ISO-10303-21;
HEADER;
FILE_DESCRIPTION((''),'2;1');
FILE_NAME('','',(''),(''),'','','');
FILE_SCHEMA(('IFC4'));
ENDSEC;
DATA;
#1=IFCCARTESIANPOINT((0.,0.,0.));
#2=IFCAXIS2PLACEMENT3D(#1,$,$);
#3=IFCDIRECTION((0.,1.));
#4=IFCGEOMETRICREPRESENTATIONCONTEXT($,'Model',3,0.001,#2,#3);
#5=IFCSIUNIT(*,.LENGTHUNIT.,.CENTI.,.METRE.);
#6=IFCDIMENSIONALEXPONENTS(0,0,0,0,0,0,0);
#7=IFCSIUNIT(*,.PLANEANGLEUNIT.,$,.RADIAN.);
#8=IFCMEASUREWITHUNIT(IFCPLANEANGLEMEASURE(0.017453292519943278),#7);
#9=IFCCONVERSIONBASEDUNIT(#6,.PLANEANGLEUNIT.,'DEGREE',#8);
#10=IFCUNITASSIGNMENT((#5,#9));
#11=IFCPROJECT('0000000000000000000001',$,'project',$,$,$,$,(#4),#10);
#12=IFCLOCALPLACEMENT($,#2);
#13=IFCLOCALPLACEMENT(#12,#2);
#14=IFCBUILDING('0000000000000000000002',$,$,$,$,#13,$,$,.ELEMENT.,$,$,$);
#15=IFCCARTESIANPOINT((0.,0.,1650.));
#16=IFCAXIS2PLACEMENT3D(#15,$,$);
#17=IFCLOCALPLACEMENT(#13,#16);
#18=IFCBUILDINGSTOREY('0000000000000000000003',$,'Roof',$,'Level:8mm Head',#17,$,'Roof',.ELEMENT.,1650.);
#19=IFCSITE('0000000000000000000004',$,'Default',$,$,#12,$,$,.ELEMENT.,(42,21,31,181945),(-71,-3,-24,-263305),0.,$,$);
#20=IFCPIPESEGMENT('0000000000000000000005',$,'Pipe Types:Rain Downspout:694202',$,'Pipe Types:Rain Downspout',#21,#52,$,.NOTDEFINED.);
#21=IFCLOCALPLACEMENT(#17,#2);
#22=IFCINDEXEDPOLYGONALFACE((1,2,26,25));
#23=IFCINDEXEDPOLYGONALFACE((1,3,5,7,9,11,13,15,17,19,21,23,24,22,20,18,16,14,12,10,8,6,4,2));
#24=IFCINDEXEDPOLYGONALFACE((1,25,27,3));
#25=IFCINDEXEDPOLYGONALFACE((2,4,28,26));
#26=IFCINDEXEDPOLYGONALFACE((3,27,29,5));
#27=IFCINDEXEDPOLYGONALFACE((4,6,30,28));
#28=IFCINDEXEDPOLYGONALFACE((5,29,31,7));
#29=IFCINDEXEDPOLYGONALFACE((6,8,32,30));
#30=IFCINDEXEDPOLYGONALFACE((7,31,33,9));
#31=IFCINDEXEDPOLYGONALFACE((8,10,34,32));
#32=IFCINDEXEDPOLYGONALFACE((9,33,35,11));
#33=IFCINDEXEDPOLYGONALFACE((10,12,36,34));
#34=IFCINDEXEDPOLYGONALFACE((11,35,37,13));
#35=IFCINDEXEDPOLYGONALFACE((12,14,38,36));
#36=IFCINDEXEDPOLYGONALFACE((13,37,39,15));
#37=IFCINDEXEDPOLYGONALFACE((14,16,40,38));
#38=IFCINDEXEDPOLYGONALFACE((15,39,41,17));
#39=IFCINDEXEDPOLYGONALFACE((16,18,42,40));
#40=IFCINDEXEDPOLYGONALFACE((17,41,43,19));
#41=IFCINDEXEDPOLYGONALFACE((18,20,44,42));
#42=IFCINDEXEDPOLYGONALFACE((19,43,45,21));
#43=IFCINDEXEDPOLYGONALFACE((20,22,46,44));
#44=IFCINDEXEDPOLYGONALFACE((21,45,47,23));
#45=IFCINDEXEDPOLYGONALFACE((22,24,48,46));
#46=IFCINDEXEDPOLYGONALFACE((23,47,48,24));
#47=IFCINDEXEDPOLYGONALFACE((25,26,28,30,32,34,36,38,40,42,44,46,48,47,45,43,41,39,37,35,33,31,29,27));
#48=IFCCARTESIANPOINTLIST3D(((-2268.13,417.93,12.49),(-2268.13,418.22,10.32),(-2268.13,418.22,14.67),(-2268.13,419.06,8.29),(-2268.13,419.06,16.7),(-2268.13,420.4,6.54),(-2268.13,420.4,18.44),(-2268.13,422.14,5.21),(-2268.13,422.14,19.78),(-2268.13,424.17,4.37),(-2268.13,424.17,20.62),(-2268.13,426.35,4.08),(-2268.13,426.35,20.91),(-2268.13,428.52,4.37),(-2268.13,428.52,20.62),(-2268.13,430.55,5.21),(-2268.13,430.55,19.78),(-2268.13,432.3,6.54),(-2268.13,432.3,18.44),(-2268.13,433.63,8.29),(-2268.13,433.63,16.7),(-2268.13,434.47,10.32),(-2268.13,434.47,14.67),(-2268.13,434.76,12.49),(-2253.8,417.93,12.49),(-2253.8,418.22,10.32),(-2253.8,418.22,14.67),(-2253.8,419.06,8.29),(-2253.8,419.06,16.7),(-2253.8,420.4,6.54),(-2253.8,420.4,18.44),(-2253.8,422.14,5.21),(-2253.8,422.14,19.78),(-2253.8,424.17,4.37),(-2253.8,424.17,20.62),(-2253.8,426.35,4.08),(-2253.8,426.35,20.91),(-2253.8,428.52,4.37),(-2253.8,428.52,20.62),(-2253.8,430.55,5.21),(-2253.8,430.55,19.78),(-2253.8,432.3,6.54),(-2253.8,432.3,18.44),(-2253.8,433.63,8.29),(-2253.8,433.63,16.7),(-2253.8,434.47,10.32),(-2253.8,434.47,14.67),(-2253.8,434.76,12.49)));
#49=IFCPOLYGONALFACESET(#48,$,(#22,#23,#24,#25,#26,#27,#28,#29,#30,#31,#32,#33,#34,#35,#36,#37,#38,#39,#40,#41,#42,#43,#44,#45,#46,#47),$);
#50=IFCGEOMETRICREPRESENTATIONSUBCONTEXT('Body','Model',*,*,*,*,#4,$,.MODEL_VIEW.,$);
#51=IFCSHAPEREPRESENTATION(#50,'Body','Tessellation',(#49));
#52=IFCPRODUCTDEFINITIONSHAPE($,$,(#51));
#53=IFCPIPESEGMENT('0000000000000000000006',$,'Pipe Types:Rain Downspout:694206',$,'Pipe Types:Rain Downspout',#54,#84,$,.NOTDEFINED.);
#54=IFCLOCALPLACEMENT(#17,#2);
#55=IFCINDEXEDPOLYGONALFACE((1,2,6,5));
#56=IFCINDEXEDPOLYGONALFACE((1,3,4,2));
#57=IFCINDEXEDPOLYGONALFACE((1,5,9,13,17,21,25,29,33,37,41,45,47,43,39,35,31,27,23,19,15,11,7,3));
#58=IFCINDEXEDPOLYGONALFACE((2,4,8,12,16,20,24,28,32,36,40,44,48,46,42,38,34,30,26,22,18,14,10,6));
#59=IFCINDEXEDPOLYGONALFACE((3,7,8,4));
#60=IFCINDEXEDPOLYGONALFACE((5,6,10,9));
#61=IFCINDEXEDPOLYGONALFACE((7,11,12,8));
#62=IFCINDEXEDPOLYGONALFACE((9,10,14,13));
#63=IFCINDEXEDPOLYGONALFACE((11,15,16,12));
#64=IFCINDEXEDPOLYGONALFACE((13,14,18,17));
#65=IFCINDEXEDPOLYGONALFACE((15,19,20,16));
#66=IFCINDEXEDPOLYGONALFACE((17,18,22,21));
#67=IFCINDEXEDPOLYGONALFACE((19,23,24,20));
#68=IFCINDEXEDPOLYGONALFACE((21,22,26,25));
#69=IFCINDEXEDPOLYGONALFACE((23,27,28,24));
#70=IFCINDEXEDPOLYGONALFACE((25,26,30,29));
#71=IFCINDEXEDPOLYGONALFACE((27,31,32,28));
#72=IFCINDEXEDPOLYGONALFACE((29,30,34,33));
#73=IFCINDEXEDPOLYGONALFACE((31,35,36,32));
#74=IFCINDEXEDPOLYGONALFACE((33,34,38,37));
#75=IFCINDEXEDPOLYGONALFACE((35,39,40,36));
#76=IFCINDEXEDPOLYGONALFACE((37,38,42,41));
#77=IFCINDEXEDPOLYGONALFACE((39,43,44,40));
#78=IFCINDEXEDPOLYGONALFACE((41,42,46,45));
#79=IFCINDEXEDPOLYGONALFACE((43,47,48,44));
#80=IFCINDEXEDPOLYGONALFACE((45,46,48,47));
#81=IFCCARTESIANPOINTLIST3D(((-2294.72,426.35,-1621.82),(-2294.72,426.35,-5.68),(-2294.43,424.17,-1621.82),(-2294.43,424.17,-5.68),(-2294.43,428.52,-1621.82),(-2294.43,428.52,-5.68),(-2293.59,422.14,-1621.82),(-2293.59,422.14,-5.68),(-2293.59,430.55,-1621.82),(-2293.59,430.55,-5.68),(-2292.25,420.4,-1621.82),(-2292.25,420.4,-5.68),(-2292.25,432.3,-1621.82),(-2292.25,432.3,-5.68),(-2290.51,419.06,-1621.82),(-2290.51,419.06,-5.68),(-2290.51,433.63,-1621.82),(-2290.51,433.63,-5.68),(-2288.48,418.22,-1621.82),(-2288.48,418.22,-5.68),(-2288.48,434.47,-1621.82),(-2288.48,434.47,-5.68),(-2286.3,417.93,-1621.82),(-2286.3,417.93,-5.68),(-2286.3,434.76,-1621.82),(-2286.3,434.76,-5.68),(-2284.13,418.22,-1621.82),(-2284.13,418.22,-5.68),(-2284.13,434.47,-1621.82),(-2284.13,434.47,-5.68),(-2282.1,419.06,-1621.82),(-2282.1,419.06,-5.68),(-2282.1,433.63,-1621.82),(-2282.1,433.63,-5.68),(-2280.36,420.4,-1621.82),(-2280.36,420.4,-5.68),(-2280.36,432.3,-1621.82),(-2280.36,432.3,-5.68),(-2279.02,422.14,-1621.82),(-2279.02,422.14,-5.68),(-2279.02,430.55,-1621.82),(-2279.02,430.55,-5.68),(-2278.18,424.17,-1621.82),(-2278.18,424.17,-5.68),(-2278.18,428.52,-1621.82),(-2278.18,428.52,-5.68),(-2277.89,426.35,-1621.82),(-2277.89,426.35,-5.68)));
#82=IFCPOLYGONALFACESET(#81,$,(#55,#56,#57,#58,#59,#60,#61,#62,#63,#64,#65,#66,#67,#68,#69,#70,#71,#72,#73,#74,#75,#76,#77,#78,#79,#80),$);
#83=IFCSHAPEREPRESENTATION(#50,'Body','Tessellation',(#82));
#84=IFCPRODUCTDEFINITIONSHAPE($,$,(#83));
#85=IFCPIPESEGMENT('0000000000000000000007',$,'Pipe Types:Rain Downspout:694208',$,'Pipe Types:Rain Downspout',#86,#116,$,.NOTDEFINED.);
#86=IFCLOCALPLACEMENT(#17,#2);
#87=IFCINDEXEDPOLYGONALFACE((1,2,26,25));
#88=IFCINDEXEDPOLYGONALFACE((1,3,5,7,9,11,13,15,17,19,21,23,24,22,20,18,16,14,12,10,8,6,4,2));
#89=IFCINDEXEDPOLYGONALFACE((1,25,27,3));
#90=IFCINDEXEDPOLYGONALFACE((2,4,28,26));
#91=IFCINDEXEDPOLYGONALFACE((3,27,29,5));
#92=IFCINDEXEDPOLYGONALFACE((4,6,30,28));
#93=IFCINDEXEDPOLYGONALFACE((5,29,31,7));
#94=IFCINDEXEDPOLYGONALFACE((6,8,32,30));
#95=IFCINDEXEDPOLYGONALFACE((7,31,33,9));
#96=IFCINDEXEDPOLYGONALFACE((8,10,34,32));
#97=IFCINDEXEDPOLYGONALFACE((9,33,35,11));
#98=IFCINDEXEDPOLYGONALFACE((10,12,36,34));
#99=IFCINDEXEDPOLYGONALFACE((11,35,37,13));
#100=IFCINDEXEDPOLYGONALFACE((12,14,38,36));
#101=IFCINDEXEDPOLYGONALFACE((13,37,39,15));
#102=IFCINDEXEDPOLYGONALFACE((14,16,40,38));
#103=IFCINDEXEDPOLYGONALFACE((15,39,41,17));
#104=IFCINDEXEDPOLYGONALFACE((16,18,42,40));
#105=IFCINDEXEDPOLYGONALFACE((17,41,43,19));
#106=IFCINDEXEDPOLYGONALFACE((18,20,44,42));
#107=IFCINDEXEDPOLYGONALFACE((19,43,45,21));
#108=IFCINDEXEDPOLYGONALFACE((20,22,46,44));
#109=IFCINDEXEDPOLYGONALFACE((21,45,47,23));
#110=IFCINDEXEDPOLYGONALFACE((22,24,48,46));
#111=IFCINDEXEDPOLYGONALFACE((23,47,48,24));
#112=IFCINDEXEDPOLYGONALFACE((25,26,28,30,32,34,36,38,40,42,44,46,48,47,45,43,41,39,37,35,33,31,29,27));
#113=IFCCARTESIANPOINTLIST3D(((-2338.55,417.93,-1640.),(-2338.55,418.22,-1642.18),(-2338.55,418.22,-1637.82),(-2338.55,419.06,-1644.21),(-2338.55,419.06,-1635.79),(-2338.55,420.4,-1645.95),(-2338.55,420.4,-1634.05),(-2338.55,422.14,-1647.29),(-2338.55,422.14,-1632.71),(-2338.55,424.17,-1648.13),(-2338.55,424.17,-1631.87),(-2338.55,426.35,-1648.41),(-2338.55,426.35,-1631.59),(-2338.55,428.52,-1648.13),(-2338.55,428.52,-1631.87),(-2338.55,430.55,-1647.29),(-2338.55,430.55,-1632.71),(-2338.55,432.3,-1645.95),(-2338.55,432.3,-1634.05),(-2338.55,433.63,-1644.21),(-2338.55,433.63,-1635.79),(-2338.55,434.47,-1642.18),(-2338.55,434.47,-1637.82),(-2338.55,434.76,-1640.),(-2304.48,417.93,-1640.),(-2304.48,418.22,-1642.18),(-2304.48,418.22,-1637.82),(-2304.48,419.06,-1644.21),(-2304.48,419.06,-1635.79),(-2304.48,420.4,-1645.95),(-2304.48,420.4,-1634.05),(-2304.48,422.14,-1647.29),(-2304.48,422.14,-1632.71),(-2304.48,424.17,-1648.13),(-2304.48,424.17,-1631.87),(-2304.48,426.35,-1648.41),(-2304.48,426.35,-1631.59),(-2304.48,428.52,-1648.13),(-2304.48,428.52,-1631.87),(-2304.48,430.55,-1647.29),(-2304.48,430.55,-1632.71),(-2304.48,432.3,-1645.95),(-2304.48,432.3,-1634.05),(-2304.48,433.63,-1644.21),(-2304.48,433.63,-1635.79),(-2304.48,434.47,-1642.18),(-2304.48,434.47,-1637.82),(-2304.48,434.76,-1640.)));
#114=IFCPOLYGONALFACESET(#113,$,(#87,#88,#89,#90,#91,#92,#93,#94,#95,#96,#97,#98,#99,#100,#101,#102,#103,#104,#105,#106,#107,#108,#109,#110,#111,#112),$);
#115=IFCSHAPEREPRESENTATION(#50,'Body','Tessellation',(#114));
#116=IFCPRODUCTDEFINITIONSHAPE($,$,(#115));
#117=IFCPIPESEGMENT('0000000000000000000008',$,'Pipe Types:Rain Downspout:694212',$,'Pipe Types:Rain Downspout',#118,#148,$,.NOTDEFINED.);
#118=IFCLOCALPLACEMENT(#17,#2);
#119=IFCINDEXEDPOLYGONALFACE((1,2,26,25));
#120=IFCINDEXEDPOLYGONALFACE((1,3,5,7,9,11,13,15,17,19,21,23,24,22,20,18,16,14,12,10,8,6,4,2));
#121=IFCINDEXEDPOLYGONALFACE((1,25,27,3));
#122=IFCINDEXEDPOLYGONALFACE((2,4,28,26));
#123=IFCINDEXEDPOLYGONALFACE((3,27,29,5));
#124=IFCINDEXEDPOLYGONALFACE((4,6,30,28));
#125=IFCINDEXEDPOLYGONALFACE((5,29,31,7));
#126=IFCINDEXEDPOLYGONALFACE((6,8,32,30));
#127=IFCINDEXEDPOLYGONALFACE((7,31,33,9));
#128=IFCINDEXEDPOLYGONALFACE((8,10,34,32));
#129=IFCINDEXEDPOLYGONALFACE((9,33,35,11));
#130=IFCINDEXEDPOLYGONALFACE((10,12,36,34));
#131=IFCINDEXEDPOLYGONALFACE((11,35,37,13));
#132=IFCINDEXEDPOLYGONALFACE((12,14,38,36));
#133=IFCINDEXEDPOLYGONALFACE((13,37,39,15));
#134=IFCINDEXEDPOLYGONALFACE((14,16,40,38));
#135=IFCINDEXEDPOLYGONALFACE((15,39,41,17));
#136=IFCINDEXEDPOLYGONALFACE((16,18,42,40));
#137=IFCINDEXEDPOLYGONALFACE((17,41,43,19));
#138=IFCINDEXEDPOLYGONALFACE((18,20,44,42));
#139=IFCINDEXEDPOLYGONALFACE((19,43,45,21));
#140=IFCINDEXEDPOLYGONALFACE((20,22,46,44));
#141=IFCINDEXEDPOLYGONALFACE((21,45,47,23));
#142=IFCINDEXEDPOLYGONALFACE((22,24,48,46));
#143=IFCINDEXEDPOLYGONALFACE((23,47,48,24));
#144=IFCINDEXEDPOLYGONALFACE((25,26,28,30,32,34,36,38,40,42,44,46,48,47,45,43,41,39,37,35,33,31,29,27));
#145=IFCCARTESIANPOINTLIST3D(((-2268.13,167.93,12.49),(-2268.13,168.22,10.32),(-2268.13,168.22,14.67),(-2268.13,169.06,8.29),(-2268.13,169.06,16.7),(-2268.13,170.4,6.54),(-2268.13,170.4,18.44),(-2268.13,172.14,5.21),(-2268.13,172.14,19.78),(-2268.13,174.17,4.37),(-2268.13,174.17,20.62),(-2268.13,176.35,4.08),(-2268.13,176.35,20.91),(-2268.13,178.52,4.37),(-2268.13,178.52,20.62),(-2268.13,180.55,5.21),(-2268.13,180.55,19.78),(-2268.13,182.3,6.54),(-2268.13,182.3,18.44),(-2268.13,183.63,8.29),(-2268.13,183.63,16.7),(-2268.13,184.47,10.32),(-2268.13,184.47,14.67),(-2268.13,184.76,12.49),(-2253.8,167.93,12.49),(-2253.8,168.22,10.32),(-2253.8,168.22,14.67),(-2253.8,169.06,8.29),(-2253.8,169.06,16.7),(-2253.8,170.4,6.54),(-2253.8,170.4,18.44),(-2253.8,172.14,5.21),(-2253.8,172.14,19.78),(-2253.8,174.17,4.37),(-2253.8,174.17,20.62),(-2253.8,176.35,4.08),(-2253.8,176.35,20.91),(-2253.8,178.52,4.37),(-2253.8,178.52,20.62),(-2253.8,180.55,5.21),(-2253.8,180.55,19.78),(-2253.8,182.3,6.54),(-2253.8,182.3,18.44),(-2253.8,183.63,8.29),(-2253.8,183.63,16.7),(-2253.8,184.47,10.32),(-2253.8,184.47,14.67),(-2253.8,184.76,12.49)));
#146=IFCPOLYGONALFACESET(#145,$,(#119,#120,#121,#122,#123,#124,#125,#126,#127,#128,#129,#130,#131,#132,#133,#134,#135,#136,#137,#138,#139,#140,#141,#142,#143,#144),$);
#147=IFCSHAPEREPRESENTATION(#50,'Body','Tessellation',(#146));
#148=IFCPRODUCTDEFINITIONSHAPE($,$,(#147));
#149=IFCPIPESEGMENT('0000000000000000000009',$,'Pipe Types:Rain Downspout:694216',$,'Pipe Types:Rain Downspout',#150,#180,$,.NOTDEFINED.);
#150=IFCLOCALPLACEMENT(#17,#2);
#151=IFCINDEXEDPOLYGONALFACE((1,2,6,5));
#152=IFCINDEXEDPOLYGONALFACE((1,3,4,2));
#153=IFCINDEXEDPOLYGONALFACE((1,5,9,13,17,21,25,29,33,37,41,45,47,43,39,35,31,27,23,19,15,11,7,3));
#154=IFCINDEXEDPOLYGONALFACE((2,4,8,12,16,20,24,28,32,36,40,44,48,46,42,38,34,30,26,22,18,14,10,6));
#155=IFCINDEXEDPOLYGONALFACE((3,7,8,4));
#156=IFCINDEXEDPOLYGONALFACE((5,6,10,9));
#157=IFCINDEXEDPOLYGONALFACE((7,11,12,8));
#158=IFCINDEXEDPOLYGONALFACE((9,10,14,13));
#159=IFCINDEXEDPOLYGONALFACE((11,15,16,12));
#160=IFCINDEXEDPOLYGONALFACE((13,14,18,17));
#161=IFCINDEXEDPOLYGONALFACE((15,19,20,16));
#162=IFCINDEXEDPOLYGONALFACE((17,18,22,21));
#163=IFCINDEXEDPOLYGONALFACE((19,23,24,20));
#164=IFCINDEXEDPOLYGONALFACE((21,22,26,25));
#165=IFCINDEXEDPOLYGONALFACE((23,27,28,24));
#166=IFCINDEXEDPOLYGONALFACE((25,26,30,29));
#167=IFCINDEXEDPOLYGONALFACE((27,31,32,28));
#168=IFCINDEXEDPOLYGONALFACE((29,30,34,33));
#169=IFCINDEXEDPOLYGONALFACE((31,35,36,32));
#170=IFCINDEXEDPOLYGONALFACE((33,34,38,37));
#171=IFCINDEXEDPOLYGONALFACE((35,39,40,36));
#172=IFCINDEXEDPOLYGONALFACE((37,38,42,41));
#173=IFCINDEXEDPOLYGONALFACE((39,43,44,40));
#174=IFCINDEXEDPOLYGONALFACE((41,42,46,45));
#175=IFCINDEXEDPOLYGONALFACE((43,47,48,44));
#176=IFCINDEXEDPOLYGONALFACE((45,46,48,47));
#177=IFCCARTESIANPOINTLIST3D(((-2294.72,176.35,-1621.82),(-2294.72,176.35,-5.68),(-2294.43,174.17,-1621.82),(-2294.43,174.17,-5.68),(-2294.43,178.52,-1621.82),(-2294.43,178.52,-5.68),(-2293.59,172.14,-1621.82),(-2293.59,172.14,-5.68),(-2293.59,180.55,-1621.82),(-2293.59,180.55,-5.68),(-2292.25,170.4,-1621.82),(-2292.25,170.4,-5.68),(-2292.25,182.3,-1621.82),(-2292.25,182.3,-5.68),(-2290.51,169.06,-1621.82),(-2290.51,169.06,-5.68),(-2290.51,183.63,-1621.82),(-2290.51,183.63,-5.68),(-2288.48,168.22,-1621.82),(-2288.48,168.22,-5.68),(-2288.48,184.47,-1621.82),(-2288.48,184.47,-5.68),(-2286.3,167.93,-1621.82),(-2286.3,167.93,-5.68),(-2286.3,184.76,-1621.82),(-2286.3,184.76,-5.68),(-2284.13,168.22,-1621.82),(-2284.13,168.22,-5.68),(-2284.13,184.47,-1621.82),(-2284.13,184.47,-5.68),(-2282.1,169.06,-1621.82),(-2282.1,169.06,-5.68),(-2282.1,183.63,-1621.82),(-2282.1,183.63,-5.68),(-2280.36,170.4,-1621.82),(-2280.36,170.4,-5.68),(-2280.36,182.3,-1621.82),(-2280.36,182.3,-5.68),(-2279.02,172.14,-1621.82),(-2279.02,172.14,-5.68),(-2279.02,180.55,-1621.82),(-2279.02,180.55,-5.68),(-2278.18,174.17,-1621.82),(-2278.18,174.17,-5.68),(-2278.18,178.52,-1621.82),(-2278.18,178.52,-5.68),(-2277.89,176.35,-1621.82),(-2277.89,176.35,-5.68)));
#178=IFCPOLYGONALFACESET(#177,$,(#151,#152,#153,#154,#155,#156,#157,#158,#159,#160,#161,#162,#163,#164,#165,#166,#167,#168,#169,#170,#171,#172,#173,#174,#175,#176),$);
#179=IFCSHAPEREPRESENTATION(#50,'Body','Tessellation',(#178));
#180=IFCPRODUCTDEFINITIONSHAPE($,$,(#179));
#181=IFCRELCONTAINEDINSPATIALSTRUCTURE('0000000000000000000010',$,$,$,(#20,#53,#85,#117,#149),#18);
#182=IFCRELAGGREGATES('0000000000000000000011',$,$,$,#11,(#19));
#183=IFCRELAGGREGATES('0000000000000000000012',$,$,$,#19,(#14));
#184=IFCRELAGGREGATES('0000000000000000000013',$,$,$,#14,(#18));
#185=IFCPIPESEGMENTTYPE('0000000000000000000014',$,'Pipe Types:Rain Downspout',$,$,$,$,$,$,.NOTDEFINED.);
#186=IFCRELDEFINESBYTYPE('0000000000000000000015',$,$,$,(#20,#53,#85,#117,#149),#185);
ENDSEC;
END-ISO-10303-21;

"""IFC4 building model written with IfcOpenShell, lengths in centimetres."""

from ifc_helpers import new_model, entity, si_unit, converted_unit, direction, frame, origin, place, context, subcontext, project, spatial, arc, indexed_curve, outline, extrude, type_object, element, save


model = new_model("IFC4")

# Units and contexts
model_context = context("Model", 3, precision=0.001, world=origin(), true_north=direction((0.0, 1.0)))
body_context = subcontext(model_context, "Body", "Model", "MODEL_VIEW")
ifc_project = project(units=[si_unit("LENGTHUNIT", "METRE", prefix="CENTI"), converted_unit("PLANEANGLEUNIT", "DEGREE", entity("IfcPlaneAngleMeasure", 0.017453292519943278), si_unit("PLANEANGLEUNIT", "RADIAN"), dimensions=[0, 0, 0, 0, 0, 0, 0])], contexts=[model_context])

# Site, building, storey
site_placement = place(None, origin())
site = spatial("IfcSite", under=ifc_project, at=site_placement, Name="Default", CompositionType="ELEMENT", RefLatitude=(42, 21, 31, 181945), RefLongitude=(-71, -3, -24, -263305), RefElevation=0.0)
building_placement = place(site_placement, origin())
building = spatial("IfcBuilding", under=site, at=building_placement, CompositionType="ELEMENT")
storey_placement = place(building_placement, frame((0.0, 0.0, 1650.0)))
storey = spatial("IfcBuildingStorey", under=building, at=storey_placement, Name="Roof", ObjectType="Level:8mm Head", LongName="Roof", CompositionType="ELEMENT", Elevation=1650.0)

# Pipe segments
pipe_segment_type = type_object("IfcPipeSegmentType", Name="Pipe Types:Rain Downspout", PredefinedType="NOTDEFINED")
pipe_segment_1_placement = place(storey_placement, origin())
element("IfcPipeSegment", 1, at=pipe_segment_1_placement, inside=storey, type_object=pipe_segment_type, Name="Pipe Types:Rain Downspout:694202", ObjectType="Pipe Types:Rain Downspout", PredefinedType="NOTDEFINED", context=body_context, shape_type="SweptSolid", body=[
    extrude(outline(indexed_curve([(8.41, 0.0), (5.95, 5.95), (0.0, 8.41), (-5.95, 5.95), (-8.41, 0.0), (-5.95, -5.95), (0.0, -8.41), (5.95, -5.95)], segments=[arc(1, 2, 3), arc(3, 4, 5), arc(5, 6, 7), arc(7, 8, 1)], self_intersect=False)), frame((-2268.13, 426.35, 12.49), z_axis=(1.0, 0.0, 0.0), x_axis=(0.0, -1.0, 0.0)), (0.0, 0.0, 1.0), 14.32),
])
pipe_segment_2_placement = place(storey_placement, origin())
element("IfcPipeSegment", 2, at=pipe_segment_2_placement, inside=storey, type_object=pipe_segment_type, Name="Pipe Types:Rain Downspout:694206", ObjectType="Pipe Types:Rain Downspout", PredefinedType="NOTDEFINED", context=body_context, shape_type="SweptSolid", body=[
    extrude(outline(indexed_curve([(8.41, 0.0), (5.95, 5.95), (0.0, 8.41), (-5.95, 5.95), (-8.41, 0.0), (-5.95, -5.95), (0.0, -8.41), (5.95, -5.95)], segments=[arc(1, 2, 3), arc(3, 4, 5), arc(5, 6, 7), arc(7, 8, 1)], self_intersect=False)), frame((-2286.3, 426.35, -1621.82)), (0.0, 0.0, 1.0), 1616.14),
])
pipe_segment_3_placement = place(storey_placement, origin())
element("IfcPipeSegment", 3, at=pipe_segment_3_placement, inside=storey, type_object=pipe_segment_type, Name="Pipe Types:Rain Downspout:694208", ObjectType="Pipe Types:Rain Downspout", PredefinedType="NOTDEFINED", context=body_context, shape_type="SweptSolid", body=[
    extrude(outline(indexed_curve([(8.41, 0.0), (5.95, 5.95), (0.0, 8.41), (-5.95, 5.95), (-8.41, 0.0), (-5.95, -5.95), (0.0, -8.41), (5.95, -5.95)], segments=[arc(1, 2, 3), arc(3, 4, 5), arc(5, 6, 7), arc(7, 8, 1)], self_intersect=False)), frame((-2338.55, 426.35, -1640.0), z_axis=(1.0, 0.0, 0.0), x_axis=(0.0, 1.0, 0.0)), (0.0, 0.0, 1.0), 34.07),
])
pipe_segment_4_placement = place(storey_placement, origin())
element("IfcPipeSegment", 4, at=pipe_segment_4_placement, inside=storey, type_object=pipe_segment_type, Name="Pipe Types:Rain Downspout:694212", ObjectType="Pipe Types:Rain Downspout", PredefinedType="NOTDEFINED", context=body_context, shape_type="SweptSolid", body=[
    extrude(outline(indexed_curve([(8.41, 0.0), (5.95, 5.95), (0.0, 8.41), (-5.95, 5.95), (-8.41, 0.0), (-5.95, -5.95), (0.0, -8.41), (5.95, -5.95)], segments=[arc(1, 2, 3), arc(3, 4, 5), arc(5, 6, 7), arc(7, 8, 1)], self_intersect=False)), frame((-2268.13, 176.35, 12.49), z_axis=(1.0, 0.0, 0.0), x_axis=(0.0, -1.0, 0.0)), (0.0, 0.0, 1.0), 14.32),
])
pipe_segment_5_placement = place(storey_placement, origin())
element("IfcPipeSegment", 5, at=pipe_segment_5_placement, inside=storey, type_object=pipe_segment_type, Name="Pipe Types:Rain Downspout:694216", ObjectType="Pipe Types:Rain Downspout", PredefinedType="NOTDEFINED", context=body_context, shape_type="SweptSolid", body=[
    extrude(outline(indexed_curve([(8.41, 0.0), (5.95, 5.95), (0.0, 8.41), (-5.95, 5.95), (-8.41, 0.0), (-5.95, -5.95), (0.0, -8.41), (5.95, -5.95)], segments=[arc(1, 2, 3), arc(3, 4, 5), arc(5, 6, 7), arc(7, 8, 1)], self_intersect=False)), frame((-2286.3, 176.35, -1621.82)), (0.0, 0.0, 1.0), 1616.14),
])

save(model, "model.ifc")
